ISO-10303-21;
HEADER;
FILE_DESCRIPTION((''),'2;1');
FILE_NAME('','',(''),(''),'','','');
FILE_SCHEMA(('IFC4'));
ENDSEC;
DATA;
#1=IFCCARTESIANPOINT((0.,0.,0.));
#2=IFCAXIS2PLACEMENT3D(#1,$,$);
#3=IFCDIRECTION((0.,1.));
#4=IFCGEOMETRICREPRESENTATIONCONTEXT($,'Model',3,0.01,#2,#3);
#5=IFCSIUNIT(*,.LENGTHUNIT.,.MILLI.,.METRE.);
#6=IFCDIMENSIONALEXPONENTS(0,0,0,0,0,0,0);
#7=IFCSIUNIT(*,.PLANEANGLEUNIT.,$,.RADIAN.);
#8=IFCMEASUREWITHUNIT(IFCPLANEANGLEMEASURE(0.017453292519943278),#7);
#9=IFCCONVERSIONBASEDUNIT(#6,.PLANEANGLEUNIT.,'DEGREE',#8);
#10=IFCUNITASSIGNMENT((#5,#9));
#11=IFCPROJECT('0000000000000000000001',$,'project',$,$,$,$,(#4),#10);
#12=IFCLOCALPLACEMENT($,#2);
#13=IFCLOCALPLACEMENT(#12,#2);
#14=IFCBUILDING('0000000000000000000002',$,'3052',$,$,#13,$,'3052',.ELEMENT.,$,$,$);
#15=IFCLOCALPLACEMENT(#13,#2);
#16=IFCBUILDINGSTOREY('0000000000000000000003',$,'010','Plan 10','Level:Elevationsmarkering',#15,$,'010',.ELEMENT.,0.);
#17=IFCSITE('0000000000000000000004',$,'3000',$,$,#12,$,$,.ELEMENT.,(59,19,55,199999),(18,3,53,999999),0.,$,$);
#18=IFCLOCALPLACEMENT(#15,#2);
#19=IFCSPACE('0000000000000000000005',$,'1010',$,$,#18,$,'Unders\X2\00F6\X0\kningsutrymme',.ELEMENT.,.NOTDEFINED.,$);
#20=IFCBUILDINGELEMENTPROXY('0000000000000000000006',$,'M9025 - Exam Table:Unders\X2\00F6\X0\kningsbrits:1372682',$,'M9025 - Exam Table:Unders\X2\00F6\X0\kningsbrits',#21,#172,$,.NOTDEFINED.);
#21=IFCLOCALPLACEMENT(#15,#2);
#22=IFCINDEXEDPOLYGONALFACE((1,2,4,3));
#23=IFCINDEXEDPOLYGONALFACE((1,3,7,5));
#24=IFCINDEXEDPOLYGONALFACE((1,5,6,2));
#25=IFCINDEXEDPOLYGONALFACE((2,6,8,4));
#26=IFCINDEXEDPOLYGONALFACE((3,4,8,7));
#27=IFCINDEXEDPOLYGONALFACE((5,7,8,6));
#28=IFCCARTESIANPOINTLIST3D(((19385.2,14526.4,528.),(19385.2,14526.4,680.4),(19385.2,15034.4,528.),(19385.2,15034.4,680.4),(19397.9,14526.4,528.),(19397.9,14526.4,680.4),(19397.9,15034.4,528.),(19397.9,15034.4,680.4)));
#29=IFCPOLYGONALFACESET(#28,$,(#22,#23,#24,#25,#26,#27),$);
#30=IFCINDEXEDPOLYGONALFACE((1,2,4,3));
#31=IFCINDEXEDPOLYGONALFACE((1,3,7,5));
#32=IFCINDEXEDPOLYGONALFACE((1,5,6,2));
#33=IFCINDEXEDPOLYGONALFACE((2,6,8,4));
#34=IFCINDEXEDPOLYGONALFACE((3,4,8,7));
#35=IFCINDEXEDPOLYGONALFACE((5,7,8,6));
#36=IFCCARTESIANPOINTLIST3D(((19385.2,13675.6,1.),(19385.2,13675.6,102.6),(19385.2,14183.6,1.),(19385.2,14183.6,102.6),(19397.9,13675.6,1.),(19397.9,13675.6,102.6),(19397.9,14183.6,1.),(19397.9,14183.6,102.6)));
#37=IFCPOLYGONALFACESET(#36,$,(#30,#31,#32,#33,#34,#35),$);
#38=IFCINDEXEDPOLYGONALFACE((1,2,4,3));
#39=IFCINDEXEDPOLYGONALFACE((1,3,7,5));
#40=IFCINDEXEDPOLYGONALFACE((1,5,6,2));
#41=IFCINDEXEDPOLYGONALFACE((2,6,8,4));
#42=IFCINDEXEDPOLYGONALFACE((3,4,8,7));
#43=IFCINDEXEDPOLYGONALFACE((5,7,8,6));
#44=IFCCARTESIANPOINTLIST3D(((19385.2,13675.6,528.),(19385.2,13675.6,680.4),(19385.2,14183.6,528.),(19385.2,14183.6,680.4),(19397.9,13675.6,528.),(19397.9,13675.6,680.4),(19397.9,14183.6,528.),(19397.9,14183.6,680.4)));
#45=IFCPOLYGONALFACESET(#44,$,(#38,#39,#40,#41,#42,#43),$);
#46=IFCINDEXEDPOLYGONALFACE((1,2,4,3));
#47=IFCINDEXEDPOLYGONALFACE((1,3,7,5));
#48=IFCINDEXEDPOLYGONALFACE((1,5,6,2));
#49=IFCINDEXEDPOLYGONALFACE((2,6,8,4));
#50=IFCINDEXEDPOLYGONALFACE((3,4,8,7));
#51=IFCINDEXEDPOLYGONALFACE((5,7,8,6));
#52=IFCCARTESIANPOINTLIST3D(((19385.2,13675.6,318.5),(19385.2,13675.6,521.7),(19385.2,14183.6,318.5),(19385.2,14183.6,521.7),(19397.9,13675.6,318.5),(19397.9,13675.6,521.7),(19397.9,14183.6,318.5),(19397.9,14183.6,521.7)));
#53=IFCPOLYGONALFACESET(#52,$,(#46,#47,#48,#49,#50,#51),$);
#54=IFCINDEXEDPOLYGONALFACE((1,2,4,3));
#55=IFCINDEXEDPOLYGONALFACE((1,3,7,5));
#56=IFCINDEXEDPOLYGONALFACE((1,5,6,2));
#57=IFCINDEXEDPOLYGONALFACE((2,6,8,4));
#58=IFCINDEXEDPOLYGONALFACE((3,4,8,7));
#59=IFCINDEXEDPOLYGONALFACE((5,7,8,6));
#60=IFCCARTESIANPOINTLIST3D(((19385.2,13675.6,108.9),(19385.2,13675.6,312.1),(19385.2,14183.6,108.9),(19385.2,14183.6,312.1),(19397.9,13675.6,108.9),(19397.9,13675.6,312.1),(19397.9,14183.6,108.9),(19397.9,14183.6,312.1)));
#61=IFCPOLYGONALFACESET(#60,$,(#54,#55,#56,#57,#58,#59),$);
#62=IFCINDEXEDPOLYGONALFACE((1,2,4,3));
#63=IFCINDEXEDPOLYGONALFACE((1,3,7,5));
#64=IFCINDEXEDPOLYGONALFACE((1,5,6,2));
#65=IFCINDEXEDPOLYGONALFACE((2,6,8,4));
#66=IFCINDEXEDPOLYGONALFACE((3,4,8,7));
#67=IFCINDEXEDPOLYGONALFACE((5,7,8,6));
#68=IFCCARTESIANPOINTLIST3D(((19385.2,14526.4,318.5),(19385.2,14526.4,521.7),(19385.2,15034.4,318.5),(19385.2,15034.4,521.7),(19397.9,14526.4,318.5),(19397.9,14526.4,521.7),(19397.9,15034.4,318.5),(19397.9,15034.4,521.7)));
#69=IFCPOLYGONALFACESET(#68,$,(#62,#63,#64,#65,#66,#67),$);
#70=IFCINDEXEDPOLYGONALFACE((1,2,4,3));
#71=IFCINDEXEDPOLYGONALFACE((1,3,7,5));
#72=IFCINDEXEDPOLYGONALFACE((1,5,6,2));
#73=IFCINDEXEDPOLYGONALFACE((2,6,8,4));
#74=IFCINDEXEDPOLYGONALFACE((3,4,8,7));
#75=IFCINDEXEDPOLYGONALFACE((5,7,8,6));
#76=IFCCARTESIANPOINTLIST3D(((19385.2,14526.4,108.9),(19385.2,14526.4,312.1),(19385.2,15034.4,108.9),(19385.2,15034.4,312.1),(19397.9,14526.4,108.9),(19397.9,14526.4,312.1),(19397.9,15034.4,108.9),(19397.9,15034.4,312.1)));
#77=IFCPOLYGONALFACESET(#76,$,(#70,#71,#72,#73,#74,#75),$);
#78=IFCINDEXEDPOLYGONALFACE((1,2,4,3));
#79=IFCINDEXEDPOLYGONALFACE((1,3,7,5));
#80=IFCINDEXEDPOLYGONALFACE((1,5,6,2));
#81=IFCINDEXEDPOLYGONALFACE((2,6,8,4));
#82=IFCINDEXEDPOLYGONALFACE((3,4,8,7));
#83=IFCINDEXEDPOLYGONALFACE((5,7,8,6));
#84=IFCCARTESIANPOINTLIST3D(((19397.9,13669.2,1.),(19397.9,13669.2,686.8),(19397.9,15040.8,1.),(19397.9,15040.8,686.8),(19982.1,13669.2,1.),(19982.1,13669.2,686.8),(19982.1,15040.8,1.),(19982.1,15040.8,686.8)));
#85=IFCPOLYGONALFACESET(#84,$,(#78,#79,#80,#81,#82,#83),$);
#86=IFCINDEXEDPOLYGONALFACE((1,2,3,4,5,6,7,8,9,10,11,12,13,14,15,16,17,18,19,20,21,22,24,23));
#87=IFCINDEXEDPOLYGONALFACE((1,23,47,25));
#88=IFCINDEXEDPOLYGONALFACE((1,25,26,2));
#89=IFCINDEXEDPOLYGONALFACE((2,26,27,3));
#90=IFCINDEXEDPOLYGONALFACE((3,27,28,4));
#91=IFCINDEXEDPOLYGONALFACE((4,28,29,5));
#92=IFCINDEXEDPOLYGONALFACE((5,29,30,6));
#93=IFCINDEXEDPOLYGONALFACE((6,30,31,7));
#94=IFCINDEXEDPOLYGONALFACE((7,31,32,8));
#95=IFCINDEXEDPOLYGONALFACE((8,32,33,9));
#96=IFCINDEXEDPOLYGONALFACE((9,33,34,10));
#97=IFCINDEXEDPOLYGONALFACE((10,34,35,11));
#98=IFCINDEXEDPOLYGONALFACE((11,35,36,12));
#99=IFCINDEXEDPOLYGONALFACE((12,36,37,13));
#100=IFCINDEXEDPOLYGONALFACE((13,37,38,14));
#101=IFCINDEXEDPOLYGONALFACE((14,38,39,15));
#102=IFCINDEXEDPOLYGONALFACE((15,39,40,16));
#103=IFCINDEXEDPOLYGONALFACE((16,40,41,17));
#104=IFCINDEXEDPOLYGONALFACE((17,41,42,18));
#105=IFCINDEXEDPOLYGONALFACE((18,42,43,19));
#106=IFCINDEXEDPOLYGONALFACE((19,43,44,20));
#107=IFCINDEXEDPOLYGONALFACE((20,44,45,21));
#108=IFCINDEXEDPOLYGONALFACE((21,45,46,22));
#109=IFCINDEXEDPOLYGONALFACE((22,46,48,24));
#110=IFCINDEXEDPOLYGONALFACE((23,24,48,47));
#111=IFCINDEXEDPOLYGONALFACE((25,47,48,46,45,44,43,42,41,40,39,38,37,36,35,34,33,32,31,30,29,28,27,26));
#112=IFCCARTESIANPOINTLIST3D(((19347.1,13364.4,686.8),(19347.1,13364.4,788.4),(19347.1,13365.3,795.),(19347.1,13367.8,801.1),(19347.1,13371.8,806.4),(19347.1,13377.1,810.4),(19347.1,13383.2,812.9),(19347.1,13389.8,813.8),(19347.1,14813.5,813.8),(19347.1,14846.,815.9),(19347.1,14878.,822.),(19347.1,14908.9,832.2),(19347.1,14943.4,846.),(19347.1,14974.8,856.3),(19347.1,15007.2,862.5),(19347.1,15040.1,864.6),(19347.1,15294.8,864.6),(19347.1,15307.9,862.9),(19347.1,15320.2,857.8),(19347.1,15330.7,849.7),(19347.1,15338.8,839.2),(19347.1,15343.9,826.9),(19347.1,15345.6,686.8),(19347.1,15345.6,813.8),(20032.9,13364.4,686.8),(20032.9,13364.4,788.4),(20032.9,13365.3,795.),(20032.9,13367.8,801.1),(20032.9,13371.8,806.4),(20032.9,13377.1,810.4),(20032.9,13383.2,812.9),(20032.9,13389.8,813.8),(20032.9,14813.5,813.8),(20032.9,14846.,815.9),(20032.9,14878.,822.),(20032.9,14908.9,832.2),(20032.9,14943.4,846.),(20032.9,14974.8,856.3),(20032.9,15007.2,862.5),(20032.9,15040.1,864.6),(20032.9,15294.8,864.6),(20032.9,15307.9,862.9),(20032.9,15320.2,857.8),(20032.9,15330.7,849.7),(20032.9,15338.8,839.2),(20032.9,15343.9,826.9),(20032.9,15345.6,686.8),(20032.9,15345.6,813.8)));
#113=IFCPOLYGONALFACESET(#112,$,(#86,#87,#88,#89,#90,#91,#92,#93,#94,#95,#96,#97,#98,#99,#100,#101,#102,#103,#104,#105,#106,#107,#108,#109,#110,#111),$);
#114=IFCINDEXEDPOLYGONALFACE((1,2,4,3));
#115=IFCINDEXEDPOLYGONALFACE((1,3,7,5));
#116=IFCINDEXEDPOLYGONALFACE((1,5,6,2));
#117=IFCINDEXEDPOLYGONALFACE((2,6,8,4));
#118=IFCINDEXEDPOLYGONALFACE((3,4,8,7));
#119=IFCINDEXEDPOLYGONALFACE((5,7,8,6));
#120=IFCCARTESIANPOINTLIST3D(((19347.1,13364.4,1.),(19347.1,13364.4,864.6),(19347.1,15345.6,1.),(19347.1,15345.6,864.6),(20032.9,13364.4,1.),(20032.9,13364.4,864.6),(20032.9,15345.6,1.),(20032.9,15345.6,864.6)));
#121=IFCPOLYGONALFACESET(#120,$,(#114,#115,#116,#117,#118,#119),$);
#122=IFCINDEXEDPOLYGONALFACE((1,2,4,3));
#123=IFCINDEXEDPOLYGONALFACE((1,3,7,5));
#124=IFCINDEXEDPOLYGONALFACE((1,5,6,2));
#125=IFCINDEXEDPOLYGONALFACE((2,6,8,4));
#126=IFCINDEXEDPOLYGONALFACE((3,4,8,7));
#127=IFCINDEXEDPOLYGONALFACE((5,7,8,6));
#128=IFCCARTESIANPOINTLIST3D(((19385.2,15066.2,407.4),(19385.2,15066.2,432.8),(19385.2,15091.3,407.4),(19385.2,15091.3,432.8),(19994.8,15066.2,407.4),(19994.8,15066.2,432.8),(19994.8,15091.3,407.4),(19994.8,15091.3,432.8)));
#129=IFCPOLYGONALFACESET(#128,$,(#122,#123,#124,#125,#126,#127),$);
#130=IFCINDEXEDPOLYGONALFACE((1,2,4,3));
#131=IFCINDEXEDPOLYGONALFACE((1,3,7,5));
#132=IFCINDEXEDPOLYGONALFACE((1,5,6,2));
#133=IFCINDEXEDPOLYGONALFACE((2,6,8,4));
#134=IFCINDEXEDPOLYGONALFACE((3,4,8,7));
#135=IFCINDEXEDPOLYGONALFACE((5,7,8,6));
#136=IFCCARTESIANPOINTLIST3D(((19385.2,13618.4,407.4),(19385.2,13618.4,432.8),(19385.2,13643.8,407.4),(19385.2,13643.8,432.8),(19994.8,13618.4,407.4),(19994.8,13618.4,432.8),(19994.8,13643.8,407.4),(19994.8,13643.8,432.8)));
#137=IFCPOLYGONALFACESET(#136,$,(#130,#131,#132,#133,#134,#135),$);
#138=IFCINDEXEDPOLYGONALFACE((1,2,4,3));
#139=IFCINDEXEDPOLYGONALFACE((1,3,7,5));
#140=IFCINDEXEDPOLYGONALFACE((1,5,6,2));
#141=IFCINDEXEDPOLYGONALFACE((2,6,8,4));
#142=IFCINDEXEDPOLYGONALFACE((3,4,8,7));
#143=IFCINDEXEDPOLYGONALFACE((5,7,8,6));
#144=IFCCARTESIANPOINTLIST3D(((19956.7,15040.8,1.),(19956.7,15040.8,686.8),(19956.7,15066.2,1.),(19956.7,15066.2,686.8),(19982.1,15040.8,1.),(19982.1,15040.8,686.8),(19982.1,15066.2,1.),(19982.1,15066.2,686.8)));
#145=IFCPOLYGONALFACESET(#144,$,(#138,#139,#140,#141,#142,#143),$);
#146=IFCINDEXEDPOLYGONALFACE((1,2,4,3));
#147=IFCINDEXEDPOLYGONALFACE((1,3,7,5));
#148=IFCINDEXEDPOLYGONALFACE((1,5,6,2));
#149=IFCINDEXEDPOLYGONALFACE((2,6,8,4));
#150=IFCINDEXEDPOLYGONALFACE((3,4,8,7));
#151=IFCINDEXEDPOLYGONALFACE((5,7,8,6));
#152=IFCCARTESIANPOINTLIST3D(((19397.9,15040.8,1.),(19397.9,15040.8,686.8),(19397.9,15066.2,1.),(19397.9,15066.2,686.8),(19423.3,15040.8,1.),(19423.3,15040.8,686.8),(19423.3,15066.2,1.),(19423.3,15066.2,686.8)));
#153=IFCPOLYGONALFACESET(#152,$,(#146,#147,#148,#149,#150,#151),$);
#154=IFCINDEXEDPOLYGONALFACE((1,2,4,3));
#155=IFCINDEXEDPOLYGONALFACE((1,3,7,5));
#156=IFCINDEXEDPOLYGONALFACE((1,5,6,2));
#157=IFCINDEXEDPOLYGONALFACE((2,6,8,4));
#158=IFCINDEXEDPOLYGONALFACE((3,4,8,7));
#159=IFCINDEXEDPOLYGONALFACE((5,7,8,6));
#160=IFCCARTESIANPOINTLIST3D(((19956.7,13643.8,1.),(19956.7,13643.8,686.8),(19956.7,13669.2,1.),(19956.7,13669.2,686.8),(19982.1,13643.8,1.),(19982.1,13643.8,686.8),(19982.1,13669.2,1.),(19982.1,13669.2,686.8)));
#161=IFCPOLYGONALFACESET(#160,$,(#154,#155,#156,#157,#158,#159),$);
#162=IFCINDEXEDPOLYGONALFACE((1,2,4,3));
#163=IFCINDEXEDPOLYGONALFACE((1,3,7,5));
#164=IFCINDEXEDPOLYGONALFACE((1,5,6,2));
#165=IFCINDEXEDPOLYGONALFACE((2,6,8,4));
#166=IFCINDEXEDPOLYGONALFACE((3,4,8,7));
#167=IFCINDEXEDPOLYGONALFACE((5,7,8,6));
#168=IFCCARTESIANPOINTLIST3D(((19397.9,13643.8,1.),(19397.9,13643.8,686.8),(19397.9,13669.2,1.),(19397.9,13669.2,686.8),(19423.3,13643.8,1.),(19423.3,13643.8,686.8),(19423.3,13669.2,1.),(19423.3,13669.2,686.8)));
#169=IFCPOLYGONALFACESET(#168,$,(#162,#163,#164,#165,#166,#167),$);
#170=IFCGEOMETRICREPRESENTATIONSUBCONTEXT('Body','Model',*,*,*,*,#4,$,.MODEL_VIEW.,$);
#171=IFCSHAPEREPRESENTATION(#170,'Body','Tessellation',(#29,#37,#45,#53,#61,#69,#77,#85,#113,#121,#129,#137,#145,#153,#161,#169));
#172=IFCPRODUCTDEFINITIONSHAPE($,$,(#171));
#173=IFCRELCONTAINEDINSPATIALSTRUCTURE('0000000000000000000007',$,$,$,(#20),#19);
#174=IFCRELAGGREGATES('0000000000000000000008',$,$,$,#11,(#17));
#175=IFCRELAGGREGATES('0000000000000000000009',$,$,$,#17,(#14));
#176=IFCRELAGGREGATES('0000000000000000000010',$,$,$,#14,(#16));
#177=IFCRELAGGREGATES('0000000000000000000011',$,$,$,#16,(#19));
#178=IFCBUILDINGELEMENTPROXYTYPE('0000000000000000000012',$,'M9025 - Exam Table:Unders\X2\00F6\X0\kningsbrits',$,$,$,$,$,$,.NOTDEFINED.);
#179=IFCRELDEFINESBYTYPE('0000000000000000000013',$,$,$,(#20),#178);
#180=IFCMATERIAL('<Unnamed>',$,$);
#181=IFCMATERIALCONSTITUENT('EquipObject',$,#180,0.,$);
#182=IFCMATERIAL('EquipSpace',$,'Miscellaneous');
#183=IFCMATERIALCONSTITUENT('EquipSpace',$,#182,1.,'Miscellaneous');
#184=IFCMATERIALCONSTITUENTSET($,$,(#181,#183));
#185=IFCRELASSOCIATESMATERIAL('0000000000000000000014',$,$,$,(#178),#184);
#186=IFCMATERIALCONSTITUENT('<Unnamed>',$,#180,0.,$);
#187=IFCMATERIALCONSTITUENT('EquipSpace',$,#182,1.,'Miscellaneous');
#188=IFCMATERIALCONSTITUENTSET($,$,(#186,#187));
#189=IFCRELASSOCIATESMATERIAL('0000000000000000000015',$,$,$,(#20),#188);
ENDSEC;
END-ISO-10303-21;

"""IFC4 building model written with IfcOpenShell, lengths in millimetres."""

from ifc_helpers import new_model, entity, si_unit, converted_unit, direction, frame, origin, place, context, subcontext, project, spatial, line, arc, indexed_curve, outline, extrude, source, transform, mapped, material, constituent, constituent_set, type_object, type_shapes, element, save


model = new_model("IFC4")

# Units and contexts
model_context = context("Model", 3, precision=0.01, world=origin(), true_north=direction((0.0, 1.0)))
body_context = subcontext(model_context, "Body", "Model", "MODEL_VIEW")
ifc_project = project(units=[si_unit("LENGTHUNIT", "METRE", prefix="MILLI"), converted_unit("PLANEANGLEUNIT", "DEGREE", entity("IfcPlaneAngleMeasure", 0.017453292519943278), si_unit("PLANEANGLEUNIT", "RADIAN"), dimensions=[0, 0, 0, 0, 0, 0, 0])], contexts=[model_context])

# Site, building, storey
site_placement = place(None, origin())
site = spatial("IfcSite", under=ifc_project, at=site_placement, Name="3000", CompositionType="ELEMENT", RefLatitude=(59, 19, 55, 199999), RefLongitude=(18, 3, 53, 999999), RefElevation=0.0)
building_placement = place(site_placement, origin())
building = spatial("IfcBuilding", under=site, at=building_placement, Name="3052", LongName="3052", CompositionType="ELEMENT")
storey_placement = place(building_placement, origin())
storey = spatial("IfcBuildingStorey", under=building, at=storey_placement, Name="010", Description="Plan 10", ObjectType="Level:Elevationsmarkering", LongName="010", CompositionType="ELEMENT", Elevation=0.0)

# Shared definitions
space_1_placement = place(storey_placement, origin())
space_1 = spatial("IfcSpace", under=storey, at=space_1_placement, Name="1010", LongName="Undersökningsutrymme", CompositionType="ELEMENT", PredefinedType="NOTDEFINED")

# Building element proxy
ifc_material_1 = material(Name="<Unnamed>")
ifc_constituent_1 = constituent(ifc_material_1, Name="<Unnamed>", fraction=0.0)
ifc_material_2 = material(Name="EquipSpace", Category="Miscellaneous")
ifc_constituent_2 = constituent(ifc_material_2, Name="EquipSpace", Category="Miscellaneous", fraction=1.0)
ifc_constituent_set_1 = constituent_set(constituents=[ifc_constituent_1, ifc_constituent_2])
ifc_constituent_3 = constituent(ifc_material_1, Name="EquipObject", fraction=0.0)
ifc_constituent_4 = constituent(ifc_material_2, Name="EquipSpace", Category="Miscellaneous", fraction=1.0)
ifc_constituent_set_2 = constituent_set(constituents=[ifc_constituent_3, ifc_constituent_4])
building_element_proxy_type = type_object("IfcBuildingElementProxyType", Name="M9025 - Exam Table:Undersökningsbrits", PredefinedType="NOTDEFINED", material=ifc_constituent_set_2)
shared_shape_1 = source(origin(), body_context, "Body", "SweptSolid", [
    extrude(outline(indexed_curve([(-6.3, -254.0), (6.3, -254.0), (6.3, 254.0), (-6.3, 254.0), (-6.3, -254.0)], self_intersect=False)), frame((-298.4, 425.4, 527.0), z_axis=(0.0, 0.0, 1.0), x_axis=(-1.0, 0.0, 0.0)), (0.0, 0.0, 1.0), 152.4),
    extrude(outline(indexed_curve([(-6.3, -254.0), (6.3, -254.0), (6.3, 254.0), (-6.3, 254.0), (-6.3, -254.0)], self_intersect=False)), frame((-298.4, -425.4, 0.0), z_axis=(0.0, 0.0, 1.0), x_axis=(-1.0, 0.0, 0.0)), (0.0, 0.0, 1.0), 101.6),
    extrude(outline(indexed_curve([(-6.3, -254.0), (6.3, -254.0), (6.3, 254.0), (-6.3, 254.0), (-6.3, -254.0)], self_intersect=False)), frame((-298.4, -425.4, 527.0), z_axis=(0.0, 0.0, 1.0), x_axis=(-1.0, 0.0, 0.0)), (0.0, 0.0, 1.0), 152.4),
    extrude(outline(indexed_curve([(-6.3, -254.0), (6.3, -254.0), (6.3, 254.0), (-6.3, 254.0), (-6.3, -254.0)], self_intersect=False)), frame((-298.4, -425.4, 317.5), z_axis=(0.0, 0.0, 1.0), x_axis=(-1.0, 0.0, 0.0)), (0.0, 0.0, 1.0), 203.2),
    extrude(outline(indexed_curve([(-6.3, -254.0), (6.3, -254.0), (6.3, 254.0), (-6.3, 254.0), (-6.3, -254.0)], self_intersect=False)), frame((-298.4, -425.4, 107.9), z_axis=(0.0, 0.0, 1.0), x_axis=(-1.0, 0.0, 0.0)), (0.0, 0.0, 1.0), 203.2),
    extrude(outline(indexed_curve([(-6.3, -254.0), (6.3, -254.0), (6.3, 254.0), (-6.3, 254.0), (-6.3, -254.0)], self_intersect=False)), frame((-298.4, 425.4, 317.5), z_axis=(0.0, 0.0, 1.0), x_axis=(-1.0, 0.0, 0.0)), (0.0, 0.0, 1.0), 203.2),
    extrude(outline(indexed_curve([(-6.3, -254.0), (6.3, -254.0), (6.3, 254.0), (-6.3, 254.0), (-6.3, -254.0)], self_intersect=False)), frame((-298.4, 425.4, 107.9), z_axis=(0.0, 0.0, 1.0), x_axis=(-1.0, 0.0, 0.0)), (0.0, 0.0, 1.0), 203.2),
    extrude(outline(indexed_curve([(-292.1, -685.8), (292.1, -685.8), (292.1, 685.8), (-292.1, 685.8), (-292.1, -685.8)], self_intersect=False)), frame((0.0, 0.0, 0.0), z_axis=(0.0, 0.0, 1.0), x_axis=(-1.0, 0.0, 0.0)), (0.0, 0.0, 1.0), 685.8),
    extrude(outline(indexed_curve([(-114.3, -764.5), (12.7, -764.5), (48.6, -749.7), (63.5, -713.7), (63.5, -459.1), (58.8, -409.8), (44.9, -362.4), (31.1, -327.9), (17.4, -281.0), (12.7, -232.5), (12.7, 1191.3), (5.3, 1209.2), (-12.7, 1216.7), (-114.3, 1216.7)], segments=[line(1, 2), arc(2, 3, 4), line(4, 5), arc(5, 6, 7), line(7, 8), arc(8, 9, 10), line(10, 11), arc(11, 12, 13), line(13, 14, 1)], self_intersect=False)), frame((-342.9, 226.1, 800.1), z_axis=(1.0, 0.0, 0.0), x_axis=(0.0, 0.0, 1.0)), (0.0, 0.0, 1.0), 685.8),
    extrude(outline(indexed_curve([(-342.9, -990.6), (342.9, -990.6), (342.9, 990.6), (-342.9, 990.6), (-342.9, -990.6)], self_intersect=False)), frame((0.0, 0.0, 0.0), z_axis=(0.0, 0.0, 1.0), x_axis=(-1.0, 0.0, 0.0)), (0.0, 0.0, 1.0), 863.6),
    extrude(outline(indexed_curve([(-304.8, -12.5), (304.8, -12.5), (304.8, 12.5), (-304.8, 12.5), (-304.8, -12.5)], self_intersect=False)), frame((0.0, 723.7, 406.4), z_axis=(0.0, 0.0, 1.0), x_axis=(-1.0, 0.0, 0.0)), (0.0, 0.0, 1.0), 25.4),
    extrude(outline(indexed_curve([(-304.8, -12.7), (304.8, -12.7), (304.8, 12.7), (-304.8, 12.7), (-304.8, -12.7)], self_intersect=False)), frame((0.0, -723.9, 406.4), z_axis=(0.0, 0.0, 1.0), x_axis=(-1.0, 0.0, 0.0)), (0.0, 0.0, 1.0), 25.4),
    extrude(outline(indexed_curve([(-12.7, -12.7), (12.7, -12.7), (12.7, 12.7), (-12.7, 12.7), (-12.7, -12.7)], self_intersect=False)), frame((279.4, 698.5, 0.0), z_axis=(0.0, 0.0, 1.0), x_axis=(0.0, 1.0, 0.0)), (0.0, 0.0, 1.0), 685.8),
    extrude(outline(indexed_curve([(-12.7, -12.7), (12.7, -12.7), (12.7, 12.7), (-12.7, 12.7), (-12.7, -12.7)], self_intersect=False)), frame((-279.4, 698.5, 0.0)), (0.0, 0.0, 1.0), 685.8),
    extrude(outline(indexed_curve([(-12.7, -12.7), (12.7, -12.7), (12.7, 12.7), (-12.7, 12.7), (-12.7, -12.7)], self_intersect=False)), frame((279.4, -698.5, 0.0), z_axis=(0.0, 0.0, 1.0), x_axis=(-1.0, 0.0, 0.0)), (0.0, 0.0, 1.0), 685.8),
    extrude(outline(indexed_curve([(-12.7, -12.7), (12.7, -12.7), (12.7, 12.7), (-12.7, 12.7), (-12.7, -12.7)], self_intersect=False)), frame((-279.4, -698.5, 0.0), z_axis=(0.0, 0.0, 1.0), x_axis=(0.0, -1.0, 0.0)), (0.0, 0.0, 1.0), 685.8),
])
type_shapes(building_element_proxy_type, [shared_shape_1])
proxy_1_placement = place(space_1_placement, frame((19690.0, 14355.0, 1.0)))
element("IfcBuildingElementProxy", 1, at=proxy_1_placement, inside=space_1, type_object=building_element_proxy_type, material=ifc_constituent_set_1, Name="M9025 - Exam Table:Undersökningsbrits:1372682", ObjectType="M9025 - Exam Table:Undersökningsbrits", PredefinedType="NOTDEFINED", context=body_context, shape_type="MappedRepresentation", body=[
    mapped(shared_shape_1, transform((0.0, 0.0, 0.0), scale=1.0)),
])

save(model, "model.ifc")
